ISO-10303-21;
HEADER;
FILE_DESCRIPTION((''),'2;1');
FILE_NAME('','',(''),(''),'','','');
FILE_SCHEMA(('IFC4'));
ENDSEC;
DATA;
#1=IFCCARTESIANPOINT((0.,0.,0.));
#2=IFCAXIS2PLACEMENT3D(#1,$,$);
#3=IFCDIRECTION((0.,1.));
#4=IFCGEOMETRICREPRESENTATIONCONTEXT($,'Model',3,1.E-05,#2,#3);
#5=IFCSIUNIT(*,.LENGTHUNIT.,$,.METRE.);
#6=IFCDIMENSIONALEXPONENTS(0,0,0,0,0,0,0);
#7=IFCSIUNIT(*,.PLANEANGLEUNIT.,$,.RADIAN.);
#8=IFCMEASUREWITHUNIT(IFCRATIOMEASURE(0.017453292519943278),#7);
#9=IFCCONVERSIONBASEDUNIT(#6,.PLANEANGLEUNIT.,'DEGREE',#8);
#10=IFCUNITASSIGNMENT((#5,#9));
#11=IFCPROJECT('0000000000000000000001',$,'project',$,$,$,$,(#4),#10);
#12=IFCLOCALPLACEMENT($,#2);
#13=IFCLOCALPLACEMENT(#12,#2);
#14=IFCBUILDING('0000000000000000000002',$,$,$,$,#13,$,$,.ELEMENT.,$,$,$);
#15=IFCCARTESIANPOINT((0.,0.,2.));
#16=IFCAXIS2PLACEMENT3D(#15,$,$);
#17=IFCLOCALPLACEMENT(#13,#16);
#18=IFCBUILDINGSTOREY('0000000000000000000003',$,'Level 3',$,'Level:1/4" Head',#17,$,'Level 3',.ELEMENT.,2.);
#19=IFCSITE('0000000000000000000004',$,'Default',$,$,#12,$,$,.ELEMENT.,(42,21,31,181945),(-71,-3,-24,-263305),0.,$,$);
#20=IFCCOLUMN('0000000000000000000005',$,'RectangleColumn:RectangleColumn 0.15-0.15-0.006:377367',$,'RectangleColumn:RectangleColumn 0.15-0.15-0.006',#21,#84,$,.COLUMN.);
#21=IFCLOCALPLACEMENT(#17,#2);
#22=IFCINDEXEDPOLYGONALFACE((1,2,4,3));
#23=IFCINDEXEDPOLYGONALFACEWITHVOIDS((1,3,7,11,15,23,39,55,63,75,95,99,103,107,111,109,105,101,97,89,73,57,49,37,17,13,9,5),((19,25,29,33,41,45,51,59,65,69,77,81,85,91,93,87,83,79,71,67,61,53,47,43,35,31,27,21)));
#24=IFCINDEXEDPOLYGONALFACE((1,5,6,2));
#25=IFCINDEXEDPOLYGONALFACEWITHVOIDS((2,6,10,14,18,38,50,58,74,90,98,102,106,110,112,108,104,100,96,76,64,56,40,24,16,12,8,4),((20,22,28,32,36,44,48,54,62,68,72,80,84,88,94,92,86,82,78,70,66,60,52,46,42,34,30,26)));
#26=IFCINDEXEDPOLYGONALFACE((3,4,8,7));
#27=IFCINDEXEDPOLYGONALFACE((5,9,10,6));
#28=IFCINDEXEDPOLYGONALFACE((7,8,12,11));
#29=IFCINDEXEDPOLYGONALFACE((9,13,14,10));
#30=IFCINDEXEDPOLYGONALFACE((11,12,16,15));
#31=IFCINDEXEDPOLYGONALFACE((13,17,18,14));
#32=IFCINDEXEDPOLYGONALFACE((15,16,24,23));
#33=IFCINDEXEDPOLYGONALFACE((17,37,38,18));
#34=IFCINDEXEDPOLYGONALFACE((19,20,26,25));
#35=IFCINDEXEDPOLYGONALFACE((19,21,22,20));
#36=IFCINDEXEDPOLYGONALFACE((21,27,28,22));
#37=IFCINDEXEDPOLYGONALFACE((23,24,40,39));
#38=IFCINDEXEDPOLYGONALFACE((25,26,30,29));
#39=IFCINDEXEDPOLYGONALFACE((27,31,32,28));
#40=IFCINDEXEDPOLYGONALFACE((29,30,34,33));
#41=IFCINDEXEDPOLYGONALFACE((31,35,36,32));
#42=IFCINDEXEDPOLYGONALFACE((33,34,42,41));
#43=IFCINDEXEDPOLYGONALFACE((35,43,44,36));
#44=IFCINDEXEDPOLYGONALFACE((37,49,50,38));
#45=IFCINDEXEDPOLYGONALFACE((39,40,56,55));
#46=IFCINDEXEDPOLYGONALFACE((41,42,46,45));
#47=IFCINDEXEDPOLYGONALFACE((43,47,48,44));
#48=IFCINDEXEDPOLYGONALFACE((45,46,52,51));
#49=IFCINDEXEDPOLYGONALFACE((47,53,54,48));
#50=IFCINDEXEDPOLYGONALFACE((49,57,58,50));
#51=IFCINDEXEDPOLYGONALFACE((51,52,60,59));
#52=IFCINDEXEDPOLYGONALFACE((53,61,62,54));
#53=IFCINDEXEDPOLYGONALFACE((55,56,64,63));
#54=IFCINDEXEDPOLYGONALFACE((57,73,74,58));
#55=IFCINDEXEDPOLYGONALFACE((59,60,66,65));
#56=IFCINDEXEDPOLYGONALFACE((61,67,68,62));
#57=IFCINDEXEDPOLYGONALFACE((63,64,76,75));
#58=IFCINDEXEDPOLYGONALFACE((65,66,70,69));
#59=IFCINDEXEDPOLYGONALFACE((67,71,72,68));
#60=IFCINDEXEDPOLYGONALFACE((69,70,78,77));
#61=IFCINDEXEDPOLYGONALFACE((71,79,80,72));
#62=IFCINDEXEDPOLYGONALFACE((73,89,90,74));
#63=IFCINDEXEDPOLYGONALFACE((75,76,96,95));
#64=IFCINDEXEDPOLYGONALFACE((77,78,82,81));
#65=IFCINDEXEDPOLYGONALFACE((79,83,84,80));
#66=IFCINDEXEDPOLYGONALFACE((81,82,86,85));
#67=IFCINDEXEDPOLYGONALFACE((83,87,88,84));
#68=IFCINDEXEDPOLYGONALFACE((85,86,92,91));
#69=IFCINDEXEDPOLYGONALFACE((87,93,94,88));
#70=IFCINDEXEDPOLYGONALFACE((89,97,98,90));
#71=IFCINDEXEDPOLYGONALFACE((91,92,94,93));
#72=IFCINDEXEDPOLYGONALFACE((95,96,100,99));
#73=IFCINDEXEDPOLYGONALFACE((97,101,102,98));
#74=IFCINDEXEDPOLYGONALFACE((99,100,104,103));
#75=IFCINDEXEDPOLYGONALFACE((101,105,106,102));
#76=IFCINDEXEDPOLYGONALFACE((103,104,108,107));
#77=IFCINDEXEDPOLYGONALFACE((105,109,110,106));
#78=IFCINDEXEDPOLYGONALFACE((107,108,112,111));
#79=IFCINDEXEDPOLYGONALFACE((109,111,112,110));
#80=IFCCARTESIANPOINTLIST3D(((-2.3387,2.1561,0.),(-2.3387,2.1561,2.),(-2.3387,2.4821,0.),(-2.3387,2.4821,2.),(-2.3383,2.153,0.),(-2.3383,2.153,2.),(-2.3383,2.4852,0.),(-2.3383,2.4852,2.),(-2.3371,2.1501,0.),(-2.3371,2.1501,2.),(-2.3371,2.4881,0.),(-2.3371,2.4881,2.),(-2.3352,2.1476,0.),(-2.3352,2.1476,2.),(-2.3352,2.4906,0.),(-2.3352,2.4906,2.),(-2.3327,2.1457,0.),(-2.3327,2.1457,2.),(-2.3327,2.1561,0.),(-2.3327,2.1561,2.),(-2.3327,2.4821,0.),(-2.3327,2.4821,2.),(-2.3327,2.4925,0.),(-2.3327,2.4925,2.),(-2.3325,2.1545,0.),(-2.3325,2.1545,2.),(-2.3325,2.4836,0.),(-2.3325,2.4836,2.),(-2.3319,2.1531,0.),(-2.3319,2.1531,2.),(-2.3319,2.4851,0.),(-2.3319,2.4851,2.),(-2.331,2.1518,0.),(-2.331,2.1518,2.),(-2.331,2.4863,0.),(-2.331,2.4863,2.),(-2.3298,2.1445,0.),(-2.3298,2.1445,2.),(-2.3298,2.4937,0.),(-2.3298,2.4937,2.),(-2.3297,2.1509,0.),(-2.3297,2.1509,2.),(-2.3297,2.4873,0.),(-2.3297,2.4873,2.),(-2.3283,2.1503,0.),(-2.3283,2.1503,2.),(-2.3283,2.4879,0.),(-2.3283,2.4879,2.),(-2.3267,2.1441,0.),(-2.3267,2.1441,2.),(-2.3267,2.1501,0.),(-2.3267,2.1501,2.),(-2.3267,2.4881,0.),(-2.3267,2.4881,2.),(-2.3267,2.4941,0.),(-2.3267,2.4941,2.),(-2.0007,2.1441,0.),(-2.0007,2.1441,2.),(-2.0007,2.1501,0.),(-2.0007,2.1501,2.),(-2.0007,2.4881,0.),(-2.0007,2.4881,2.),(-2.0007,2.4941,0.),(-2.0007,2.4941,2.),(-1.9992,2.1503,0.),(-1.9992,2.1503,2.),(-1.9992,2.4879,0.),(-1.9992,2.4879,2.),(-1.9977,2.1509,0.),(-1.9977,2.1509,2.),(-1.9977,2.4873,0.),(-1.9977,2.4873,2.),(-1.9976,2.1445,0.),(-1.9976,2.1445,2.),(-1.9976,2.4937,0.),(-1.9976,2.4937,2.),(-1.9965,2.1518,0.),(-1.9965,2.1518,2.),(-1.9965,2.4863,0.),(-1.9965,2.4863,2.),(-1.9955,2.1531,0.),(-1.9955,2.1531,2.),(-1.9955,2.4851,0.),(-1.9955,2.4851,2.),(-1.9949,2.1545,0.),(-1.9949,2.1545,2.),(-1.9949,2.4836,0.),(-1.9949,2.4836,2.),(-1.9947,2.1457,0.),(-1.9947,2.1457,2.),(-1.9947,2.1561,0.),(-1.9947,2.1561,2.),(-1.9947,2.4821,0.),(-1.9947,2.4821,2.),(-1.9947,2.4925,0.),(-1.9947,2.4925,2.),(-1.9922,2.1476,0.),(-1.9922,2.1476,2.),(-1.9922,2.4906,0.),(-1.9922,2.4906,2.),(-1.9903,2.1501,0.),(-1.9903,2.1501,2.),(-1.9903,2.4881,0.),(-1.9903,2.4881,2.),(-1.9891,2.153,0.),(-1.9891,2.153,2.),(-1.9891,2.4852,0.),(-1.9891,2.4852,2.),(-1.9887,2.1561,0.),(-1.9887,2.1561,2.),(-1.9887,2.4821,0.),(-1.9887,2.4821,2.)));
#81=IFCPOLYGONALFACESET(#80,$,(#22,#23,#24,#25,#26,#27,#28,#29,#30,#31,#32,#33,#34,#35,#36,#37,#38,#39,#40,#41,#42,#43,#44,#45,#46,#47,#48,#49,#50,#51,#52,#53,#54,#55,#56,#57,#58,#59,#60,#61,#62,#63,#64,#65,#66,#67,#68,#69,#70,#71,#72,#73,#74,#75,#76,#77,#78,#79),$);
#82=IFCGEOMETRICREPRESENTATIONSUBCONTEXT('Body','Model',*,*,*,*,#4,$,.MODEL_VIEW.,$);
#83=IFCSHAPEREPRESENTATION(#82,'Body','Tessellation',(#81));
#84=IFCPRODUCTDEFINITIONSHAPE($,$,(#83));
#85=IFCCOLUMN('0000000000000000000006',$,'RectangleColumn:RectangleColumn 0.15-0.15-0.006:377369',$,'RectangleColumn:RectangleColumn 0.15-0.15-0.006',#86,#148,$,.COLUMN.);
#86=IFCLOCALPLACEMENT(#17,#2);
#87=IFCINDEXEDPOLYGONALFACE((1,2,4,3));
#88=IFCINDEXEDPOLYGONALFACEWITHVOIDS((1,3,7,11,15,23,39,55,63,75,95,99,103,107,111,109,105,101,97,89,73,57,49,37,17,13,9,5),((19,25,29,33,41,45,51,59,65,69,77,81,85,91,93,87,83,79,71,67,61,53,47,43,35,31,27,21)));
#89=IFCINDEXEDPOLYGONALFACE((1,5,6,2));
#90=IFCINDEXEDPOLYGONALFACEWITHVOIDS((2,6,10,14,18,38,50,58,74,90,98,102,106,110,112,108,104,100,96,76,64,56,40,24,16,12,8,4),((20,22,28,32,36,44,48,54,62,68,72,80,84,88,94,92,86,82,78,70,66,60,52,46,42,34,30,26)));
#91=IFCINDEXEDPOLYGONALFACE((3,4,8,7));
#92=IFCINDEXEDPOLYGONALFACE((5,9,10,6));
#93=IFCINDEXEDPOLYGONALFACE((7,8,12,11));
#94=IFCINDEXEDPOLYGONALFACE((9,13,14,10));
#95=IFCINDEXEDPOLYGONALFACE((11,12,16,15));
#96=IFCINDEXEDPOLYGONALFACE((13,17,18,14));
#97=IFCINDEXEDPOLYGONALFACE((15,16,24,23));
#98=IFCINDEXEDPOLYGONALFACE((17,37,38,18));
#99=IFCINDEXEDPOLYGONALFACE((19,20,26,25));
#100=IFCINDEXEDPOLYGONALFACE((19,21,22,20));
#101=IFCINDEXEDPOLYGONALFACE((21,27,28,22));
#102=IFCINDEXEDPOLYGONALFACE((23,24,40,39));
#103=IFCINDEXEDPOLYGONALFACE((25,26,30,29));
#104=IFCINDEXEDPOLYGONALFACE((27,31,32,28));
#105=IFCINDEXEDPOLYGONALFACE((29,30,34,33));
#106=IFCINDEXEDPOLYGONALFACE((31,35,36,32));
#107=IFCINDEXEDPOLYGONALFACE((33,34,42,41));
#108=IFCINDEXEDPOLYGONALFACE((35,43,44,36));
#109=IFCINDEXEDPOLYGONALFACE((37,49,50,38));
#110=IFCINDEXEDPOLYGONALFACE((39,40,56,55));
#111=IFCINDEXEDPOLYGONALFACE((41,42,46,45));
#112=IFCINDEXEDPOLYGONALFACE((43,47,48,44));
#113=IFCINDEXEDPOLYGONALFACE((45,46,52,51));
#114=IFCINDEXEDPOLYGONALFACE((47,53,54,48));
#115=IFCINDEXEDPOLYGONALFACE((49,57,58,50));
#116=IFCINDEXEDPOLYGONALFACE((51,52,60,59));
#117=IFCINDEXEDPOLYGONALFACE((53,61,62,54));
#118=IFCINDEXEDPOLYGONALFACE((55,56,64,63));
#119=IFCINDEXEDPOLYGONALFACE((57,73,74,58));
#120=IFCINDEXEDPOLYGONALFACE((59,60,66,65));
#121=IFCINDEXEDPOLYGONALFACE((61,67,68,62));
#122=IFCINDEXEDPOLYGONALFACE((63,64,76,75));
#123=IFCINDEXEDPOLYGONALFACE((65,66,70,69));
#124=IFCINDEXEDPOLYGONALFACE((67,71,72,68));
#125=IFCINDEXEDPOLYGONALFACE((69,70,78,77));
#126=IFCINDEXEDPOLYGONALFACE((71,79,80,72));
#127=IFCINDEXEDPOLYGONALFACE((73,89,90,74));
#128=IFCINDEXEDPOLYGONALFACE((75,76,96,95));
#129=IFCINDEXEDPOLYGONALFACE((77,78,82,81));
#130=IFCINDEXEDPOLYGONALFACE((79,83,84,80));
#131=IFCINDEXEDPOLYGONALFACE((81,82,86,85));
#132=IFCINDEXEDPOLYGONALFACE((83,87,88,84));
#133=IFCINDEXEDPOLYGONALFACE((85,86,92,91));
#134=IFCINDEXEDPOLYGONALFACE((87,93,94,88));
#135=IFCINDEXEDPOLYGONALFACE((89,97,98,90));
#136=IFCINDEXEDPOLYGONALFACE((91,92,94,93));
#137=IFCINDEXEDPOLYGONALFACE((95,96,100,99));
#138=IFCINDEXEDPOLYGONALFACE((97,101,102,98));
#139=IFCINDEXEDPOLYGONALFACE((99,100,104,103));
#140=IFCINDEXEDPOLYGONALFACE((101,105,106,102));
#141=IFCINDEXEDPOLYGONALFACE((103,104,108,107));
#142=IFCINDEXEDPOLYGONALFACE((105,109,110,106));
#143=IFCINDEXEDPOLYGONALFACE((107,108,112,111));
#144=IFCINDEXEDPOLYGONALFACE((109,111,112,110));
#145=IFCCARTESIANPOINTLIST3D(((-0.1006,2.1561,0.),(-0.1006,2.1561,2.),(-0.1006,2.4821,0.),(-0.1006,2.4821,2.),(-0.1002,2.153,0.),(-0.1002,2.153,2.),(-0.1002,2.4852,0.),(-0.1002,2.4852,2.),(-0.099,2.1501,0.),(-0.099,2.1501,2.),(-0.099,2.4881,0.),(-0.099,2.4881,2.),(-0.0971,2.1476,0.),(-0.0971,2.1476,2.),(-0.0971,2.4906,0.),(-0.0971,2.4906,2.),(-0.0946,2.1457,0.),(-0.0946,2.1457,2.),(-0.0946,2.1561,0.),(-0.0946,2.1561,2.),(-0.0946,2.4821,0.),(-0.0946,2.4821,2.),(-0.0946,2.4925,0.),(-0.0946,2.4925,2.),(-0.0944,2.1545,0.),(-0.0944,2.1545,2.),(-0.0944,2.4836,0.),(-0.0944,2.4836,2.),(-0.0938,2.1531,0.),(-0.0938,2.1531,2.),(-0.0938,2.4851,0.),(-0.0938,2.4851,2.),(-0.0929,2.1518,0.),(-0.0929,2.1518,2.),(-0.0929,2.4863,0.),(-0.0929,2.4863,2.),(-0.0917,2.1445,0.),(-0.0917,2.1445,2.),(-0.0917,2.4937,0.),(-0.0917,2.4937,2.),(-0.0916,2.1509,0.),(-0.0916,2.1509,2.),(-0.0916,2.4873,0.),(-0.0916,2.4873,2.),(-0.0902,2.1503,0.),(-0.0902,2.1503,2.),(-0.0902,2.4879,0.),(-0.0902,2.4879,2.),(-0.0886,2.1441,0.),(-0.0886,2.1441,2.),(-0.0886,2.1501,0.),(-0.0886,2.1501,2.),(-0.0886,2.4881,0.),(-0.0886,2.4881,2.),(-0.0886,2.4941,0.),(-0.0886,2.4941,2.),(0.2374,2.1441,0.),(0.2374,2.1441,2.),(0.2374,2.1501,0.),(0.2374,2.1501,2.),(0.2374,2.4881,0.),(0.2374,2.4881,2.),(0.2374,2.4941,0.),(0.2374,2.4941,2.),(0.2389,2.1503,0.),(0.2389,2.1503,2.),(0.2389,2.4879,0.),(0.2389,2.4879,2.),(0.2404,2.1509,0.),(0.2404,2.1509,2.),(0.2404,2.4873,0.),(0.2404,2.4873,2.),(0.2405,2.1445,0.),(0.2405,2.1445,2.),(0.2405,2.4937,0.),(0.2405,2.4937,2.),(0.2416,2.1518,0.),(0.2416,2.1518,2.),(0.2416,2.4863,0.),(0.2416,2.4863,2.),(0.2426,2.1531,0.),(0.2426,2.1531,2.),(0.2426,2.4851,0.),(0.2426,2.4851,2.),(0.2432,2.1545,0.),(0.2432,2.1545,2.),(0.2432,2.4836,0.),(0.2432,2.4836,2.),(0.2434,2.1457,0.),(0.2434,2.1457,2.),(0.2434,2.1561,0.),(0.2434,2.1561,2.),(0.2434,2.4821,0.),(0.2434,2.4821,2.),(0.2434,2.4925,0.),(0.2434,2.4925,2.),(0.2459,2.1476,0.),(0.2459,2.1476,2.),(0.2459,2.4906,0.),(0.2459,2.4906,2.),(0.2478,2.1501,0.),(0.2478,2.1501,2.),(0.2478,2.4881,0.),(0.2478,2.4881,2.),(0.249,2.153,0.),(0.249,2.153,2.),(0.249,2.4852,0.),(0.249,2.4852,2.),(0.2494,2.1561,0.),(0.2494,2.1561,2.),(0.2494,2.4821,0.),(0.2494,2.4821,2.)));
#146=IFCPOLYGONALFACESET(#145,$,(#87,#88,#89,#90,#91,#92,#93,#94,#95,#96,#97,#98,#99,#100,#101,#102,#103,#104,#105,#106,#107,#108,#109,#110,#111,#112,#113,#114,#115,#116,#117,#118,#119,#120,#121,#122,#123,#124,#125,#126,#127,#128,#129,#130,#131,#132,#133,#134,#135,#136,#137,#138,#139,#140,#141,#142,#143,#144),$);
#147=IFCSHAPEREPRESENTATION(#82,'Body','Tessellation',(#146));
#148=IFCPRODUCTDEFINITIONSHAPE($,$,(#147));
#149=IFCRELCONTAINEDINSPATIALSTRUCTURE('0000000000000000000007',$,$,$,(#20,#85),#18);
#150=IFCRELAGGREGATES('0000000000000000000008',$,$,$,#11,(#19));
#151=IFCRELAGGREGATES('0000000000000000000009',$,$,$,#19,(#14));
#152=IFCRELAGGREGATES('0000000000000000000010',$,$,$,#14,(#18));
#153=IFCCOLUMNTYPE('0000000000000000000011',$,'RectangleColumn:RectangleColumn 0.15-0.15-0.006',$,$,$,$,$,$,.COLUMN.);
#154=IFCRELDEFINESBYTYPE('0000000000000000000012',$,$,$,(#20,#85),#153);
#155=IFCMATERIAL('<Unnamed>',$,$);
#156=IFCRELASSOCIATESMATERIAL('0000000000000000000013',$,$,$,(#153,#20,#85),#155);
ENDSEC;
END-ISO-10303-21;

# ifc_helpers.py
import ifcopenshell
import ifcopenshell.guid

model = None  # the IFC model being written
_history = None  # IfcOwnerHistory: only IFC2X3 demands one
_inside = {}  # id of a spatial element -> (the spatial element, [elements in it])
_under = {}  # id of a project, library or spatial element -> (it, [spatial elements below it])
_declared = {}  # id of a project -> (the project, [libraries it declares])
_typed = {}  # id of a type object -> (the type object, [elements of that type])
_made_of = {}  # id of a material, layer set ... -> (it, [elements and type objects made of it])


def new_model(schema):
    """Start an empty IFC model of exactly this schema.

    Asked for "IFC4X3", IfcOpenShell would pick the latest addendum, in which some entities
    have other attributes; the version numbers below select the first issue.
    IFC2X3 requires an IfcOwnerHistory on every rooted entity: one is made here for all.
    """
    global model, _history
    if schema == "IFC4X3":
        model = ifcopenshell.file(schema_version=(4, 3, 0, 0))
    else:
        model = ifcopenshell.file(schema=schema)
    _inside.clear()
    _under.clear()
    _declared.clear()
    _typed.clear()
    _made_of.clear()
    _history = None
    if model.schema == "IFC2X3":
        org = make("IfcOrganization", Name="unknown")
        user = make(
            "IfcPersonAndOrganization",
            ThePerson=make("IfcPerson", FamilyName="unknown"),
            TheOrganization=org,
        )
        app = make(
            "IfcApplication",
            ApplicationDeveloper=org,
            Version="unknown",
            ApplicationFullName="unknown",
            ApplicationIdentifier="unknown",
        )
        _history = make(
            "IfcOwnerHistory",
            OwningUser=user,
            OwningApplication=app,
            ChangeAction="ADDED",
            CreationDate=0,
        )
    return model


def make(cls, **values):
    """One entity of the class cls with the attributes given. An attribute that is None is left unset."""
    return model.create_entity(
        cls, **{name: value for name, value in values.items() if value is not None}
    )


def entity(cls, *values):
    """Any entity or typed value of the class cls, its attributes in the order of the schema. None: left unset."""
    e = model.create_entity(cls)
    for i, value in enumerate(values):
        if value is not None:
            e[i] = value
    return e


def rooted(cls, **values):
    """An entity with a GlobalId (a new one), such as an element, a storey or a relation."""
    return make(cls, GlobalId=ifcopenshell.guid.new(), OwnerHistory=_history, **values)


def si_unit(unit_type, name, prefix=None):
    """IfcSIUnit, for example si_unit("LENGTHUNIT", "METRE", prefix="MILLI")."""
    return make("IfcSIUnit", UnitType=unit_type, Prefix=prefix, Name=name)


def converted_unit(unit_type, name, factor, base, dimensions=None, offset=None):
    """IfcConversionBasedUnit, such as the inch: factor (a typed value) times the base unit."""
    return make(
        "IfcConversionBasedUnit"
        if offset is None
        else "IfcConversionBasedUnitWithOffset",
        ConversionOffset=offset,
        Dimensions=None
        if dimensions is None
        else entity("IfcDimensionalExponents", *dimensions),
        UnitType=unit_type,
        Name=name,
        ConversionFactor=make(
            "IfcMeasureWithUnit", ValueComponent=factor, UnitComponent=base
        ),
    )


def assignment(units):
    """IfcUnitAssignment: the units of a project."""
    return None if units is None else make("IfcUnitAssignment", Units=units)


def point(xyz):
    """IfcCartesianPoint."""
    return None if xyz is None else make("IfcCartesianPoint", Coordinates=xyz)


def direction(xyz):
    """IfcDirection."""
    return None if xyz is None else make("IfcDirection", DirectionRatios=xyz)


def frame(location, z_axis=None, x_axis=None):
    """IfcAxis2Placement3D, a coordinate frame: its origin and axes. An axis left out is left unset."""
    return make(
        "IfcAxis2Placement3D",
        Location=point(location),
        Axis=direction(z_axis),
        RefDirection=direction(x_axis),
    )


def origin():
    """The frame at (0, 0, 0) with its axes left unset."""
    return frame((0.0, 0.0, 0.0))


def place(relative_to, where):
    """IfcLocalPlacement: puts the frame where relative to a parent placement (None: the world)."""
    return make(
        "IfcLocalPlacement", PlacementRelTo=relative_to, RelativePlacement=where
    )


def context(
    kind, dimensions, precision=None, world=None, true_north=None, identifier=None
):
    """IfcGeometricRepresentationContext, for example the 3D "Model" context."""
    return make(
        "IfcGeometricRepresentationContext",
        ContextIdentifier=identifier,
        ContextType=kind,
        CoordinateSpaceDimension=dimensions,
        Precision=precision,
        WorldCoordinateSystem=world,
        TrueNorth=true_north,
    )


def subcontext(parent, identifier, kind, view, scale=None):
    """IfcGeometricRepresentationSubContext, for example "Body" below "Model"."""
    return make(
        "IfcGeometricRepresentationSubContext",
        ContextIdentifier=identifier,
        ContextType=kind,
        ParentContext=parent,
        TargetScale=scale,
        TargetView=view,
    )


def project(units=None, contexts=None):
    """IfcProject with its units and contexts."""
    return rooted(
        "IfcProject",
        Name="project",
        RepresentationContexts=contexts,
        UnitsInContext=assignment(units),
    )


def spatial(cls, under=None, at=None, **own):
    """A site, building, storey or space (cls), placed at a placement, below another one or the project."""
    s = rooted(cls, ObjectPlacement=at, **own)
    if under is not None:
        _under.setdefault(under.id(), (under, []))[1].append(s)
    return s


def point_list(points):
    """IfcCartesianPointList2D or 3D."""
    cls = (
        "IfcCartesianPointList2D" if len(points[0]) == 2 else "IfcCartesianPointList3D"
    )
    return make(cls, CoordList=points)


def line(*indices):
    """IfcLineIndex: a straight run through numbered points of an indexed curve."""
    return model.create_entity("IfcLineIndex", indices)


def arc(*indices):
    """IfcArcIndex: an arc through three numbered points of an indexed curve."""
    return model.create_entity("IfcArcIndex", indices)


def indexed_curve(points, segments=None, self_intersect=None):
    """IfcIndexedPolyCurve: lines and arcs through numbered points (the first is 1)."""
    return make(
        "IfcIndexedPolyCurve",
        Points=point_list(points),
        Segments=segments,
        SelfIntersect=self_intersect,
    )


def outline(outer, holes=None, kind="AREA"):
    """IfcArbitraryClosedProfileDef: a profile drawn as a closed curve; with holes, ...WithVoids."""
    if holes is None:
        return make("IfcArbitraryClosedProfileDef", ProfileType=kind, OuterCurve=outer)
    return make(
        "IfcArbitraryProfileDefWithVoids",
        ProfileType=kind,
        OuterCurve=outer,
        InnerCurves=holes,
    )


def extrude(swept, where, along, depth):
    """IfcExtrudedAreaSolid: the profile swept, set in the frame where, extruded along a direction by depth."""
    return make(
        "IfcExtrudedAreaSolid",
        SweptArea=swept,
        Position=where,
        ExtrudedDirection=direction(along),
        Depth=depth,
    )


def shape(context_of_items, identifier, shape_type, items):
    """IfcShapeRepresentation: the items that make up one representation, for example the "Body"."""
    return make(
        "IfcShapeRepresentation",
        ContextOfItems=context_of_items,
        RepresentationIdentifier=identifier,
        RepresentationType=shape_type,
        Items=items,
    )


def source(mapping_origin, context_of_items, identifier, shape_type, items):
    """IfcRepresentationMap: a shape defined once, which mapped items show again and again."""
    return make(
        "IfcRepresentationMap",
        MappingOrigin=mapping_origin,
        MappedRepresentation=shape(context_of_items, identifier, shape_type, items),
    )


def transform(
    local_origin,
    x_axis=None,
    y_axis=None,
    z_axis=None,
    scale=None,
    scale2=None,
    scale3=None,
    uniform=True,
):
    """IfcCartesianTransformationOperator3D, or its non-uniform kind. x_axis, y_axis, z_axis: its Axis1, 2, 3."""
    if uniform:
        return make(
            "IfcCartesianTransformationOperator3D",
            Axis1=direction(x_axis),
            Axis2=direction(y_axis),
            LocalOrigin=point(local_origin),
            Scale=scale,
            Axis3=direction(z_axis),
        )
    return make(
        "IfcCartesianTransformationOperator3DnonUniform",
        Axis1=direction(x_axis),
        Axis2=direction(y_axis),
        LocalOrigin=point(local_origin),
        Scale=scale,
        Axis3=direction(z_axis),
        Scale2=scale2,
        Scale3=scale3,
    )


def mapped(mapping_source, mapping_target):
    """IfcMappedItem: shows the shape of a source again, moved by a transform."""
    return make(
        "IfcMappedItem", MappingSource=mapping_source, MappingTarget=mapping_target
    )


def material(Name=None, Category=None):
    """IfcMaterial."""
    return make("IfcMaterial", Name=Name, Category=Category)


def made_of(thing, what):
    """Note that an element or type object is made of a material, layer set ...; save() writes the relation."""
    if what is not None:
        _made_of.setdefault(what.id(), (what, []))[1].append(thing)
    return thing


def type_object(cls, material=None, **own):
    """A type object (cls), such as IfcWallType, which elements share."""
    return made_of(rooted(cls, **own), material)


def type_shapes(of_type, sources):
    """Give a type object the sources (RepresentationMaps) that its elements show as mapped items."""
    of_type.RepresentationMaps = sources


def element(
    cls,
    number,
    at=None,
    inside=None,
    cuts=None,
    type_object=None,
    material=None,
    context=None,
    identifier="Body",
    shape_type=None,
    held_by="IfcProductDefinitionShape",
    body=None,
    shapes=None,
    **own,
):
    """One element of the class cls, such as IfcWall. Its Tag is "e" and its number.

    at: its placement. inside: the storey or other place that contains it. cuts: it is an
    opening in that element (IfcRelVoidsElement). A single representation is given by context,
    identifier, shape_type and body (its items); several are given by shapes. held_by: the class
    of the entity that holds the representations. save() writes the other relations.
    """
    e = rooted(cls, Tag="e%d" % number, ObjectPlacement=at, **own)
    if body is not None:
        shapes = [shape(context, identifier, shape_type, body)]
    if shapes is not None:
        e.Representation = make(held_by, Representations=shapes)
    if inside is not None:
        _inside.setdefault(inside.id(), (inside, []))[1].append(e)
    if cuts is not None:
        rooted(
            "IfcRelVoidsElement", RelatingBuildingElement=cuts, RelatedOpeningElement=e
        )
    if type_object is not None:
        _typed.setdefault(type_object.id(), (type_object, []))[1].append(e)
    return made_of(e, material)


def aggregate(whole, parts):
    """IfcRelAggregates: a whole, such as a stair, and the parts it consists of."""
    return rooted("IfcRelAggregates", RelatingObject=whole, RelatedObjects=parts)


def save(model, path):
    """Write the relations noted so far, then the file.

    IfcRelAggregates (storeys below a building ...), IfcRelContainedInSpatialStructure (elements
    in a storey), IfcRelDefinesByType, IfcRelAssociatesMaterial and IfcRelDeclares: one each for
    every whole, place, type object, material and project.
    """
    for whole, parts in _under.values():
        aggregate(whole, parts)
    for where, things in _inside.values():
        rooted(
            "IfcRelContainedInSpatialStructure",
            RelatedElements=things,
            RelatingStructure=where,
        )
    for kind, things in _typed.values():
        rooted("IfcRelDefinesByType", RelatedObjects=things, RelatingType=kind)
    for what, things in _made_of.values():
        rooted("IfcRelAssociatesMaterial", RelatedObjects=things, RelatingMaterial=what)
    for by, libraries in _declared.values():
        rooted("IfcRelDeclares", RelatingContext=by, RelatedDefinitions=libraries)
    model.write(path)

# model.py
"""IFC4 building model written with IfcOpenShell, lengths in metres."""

from ifc_helpers import new_model, entity, si_unit, converted_unit, direction, frame, origin, place, context, subcontext, project, spatial, line, arc, indexed_curve, outline, extrude, source, transform, mapped, material, type_object, type_shapes, element, save


model = new_model("IFC4")

# Units and contexts
model_context = context("Model", 3, precision=1e-05, world=origin(), true_north=direction((0.0, 1.0)))
body_context = subcontext(model_context, "Body", "Model", "MODEL_VIEW")
ifc_project = project(units=[si_unit("LENGTHUNIT", "METRE"), converted_unit("PLANEANGLEUNIT", "DEGREE", entity("IfcRatioMeasure", 0.017453292519943278), si_unit("PLANEANGLEUNIT", "RADIAN"), dimensions=[0, 0, 0, 0, 0, 0, 0])], contexts=[model_context])

# Site, building, storey
site_placement = place(None, origin())
site = spatial("IfcSite", under=ifc_project, at=site_placement, Name="Default", CompositionType="ELEMENT", RefLatitude=(42, 21, 31, 181945), RefLongitude=(-71, -3, -24, -263305), RefElevation=0.0)
building_placement = place(site_placement, origin())
building = spatial("IfcBuilding", under=site, at=building_placement, CompositionType="ELEMENT")
storey_placement = place(building_placement, frame((0.0, 0.0, 2.0)))
storey = spatial("IfcBuildingStorey", under=building, at=storey_placement, Name="Level 3", ObjectType="Level:1/4\" Head", LongName="Level 3", CompositionType="ELEMENT", Elevation=2.0)

# Columns
ifc_material_1 = material(Name="<Unnamed>")
column_type = type_object("IfcColumnType", Name="RectangleColumn:RectangleColumn 0.15-0.15-0.006", PredefinedType="COLUMN", material=ifc_material_1)
shared_shape = source(origin(), body_context, "Body", "SweptSolid", [
    extrude(outline(indexed_curve([(-0.163, -0.175), (0.163, -0.175), (0.1715, -0.1715), (0.175, -0.163), (0.175, 0.163), (0.1715, 0.1715), (0.163, 0.175), (-0.163, 0.175), (-0.1715, 0.1715), (-0.175, 0.163), (-0.175, -0.163), (-0.1715, -0.1715)], segments=[line(1, 2), arc(2, 3, 4), line(4, 5), arc(5, 6, 7), line(7, 8), arc(8, 9, 10), line(10, 11), arc(11, 12, 1)], self_intersect=False), holes=[indexed_curve([(-0.163, -0.169), (-0.1672, -0.1672), (-0.169, -0.163), (-0.169, 0.163), (-0.1672, 0.1672), (-0.163, 0.169), (0.163, 0.169), (0.1672, 0.1672), (0.169, 0.163), (0.169, -0.163), (0.1672, -0.1672), (0.163, -0.169)], segments=[arc(1, 2, 3), line(3, 4), arc(4, 5, 6), line(6, 7), arc(7, 8, 9), line(9, 10), arc(10, 11, 12), line(12, 1)], self_intersect=False)]), frame((0.0, 0.0, 2.0), z_axis=(0.0, 0.0, 1.0), x_axis=(-1.0, 0.0, 0.0)), (0.0, 0.0, 1.0), 2.0),
])
type_shapes(column_type, [shared_shape])
for number, where, name in (
    (1, (-2.1637, 2.3191, -2.0), "RectangleColumn:RectangleColumn 0.15-0.15-0.006:377367"),
    (2, (0.0744, 2.3191, -2.0), "RectangleColumn:RectangleColumn 0.15-0.15-0.006:377369"),
):
    element("IfcColumn", number, at=place(storey_placement, frame(where)), inside=storey, type_object=column_type, material=ifc_material_1, Name=name, ObjectType="RectangleColumn:RectangleColumn 0.15-0.15-0.006", PredefinedType="COLUMN", context=body_context, shape_type="MappedRepresentation", body=[
        mapped(shared_shape, transform((0.0, 0.0, 0.0), scale=1.0)),
    ])

save(model, "model.ifc")
